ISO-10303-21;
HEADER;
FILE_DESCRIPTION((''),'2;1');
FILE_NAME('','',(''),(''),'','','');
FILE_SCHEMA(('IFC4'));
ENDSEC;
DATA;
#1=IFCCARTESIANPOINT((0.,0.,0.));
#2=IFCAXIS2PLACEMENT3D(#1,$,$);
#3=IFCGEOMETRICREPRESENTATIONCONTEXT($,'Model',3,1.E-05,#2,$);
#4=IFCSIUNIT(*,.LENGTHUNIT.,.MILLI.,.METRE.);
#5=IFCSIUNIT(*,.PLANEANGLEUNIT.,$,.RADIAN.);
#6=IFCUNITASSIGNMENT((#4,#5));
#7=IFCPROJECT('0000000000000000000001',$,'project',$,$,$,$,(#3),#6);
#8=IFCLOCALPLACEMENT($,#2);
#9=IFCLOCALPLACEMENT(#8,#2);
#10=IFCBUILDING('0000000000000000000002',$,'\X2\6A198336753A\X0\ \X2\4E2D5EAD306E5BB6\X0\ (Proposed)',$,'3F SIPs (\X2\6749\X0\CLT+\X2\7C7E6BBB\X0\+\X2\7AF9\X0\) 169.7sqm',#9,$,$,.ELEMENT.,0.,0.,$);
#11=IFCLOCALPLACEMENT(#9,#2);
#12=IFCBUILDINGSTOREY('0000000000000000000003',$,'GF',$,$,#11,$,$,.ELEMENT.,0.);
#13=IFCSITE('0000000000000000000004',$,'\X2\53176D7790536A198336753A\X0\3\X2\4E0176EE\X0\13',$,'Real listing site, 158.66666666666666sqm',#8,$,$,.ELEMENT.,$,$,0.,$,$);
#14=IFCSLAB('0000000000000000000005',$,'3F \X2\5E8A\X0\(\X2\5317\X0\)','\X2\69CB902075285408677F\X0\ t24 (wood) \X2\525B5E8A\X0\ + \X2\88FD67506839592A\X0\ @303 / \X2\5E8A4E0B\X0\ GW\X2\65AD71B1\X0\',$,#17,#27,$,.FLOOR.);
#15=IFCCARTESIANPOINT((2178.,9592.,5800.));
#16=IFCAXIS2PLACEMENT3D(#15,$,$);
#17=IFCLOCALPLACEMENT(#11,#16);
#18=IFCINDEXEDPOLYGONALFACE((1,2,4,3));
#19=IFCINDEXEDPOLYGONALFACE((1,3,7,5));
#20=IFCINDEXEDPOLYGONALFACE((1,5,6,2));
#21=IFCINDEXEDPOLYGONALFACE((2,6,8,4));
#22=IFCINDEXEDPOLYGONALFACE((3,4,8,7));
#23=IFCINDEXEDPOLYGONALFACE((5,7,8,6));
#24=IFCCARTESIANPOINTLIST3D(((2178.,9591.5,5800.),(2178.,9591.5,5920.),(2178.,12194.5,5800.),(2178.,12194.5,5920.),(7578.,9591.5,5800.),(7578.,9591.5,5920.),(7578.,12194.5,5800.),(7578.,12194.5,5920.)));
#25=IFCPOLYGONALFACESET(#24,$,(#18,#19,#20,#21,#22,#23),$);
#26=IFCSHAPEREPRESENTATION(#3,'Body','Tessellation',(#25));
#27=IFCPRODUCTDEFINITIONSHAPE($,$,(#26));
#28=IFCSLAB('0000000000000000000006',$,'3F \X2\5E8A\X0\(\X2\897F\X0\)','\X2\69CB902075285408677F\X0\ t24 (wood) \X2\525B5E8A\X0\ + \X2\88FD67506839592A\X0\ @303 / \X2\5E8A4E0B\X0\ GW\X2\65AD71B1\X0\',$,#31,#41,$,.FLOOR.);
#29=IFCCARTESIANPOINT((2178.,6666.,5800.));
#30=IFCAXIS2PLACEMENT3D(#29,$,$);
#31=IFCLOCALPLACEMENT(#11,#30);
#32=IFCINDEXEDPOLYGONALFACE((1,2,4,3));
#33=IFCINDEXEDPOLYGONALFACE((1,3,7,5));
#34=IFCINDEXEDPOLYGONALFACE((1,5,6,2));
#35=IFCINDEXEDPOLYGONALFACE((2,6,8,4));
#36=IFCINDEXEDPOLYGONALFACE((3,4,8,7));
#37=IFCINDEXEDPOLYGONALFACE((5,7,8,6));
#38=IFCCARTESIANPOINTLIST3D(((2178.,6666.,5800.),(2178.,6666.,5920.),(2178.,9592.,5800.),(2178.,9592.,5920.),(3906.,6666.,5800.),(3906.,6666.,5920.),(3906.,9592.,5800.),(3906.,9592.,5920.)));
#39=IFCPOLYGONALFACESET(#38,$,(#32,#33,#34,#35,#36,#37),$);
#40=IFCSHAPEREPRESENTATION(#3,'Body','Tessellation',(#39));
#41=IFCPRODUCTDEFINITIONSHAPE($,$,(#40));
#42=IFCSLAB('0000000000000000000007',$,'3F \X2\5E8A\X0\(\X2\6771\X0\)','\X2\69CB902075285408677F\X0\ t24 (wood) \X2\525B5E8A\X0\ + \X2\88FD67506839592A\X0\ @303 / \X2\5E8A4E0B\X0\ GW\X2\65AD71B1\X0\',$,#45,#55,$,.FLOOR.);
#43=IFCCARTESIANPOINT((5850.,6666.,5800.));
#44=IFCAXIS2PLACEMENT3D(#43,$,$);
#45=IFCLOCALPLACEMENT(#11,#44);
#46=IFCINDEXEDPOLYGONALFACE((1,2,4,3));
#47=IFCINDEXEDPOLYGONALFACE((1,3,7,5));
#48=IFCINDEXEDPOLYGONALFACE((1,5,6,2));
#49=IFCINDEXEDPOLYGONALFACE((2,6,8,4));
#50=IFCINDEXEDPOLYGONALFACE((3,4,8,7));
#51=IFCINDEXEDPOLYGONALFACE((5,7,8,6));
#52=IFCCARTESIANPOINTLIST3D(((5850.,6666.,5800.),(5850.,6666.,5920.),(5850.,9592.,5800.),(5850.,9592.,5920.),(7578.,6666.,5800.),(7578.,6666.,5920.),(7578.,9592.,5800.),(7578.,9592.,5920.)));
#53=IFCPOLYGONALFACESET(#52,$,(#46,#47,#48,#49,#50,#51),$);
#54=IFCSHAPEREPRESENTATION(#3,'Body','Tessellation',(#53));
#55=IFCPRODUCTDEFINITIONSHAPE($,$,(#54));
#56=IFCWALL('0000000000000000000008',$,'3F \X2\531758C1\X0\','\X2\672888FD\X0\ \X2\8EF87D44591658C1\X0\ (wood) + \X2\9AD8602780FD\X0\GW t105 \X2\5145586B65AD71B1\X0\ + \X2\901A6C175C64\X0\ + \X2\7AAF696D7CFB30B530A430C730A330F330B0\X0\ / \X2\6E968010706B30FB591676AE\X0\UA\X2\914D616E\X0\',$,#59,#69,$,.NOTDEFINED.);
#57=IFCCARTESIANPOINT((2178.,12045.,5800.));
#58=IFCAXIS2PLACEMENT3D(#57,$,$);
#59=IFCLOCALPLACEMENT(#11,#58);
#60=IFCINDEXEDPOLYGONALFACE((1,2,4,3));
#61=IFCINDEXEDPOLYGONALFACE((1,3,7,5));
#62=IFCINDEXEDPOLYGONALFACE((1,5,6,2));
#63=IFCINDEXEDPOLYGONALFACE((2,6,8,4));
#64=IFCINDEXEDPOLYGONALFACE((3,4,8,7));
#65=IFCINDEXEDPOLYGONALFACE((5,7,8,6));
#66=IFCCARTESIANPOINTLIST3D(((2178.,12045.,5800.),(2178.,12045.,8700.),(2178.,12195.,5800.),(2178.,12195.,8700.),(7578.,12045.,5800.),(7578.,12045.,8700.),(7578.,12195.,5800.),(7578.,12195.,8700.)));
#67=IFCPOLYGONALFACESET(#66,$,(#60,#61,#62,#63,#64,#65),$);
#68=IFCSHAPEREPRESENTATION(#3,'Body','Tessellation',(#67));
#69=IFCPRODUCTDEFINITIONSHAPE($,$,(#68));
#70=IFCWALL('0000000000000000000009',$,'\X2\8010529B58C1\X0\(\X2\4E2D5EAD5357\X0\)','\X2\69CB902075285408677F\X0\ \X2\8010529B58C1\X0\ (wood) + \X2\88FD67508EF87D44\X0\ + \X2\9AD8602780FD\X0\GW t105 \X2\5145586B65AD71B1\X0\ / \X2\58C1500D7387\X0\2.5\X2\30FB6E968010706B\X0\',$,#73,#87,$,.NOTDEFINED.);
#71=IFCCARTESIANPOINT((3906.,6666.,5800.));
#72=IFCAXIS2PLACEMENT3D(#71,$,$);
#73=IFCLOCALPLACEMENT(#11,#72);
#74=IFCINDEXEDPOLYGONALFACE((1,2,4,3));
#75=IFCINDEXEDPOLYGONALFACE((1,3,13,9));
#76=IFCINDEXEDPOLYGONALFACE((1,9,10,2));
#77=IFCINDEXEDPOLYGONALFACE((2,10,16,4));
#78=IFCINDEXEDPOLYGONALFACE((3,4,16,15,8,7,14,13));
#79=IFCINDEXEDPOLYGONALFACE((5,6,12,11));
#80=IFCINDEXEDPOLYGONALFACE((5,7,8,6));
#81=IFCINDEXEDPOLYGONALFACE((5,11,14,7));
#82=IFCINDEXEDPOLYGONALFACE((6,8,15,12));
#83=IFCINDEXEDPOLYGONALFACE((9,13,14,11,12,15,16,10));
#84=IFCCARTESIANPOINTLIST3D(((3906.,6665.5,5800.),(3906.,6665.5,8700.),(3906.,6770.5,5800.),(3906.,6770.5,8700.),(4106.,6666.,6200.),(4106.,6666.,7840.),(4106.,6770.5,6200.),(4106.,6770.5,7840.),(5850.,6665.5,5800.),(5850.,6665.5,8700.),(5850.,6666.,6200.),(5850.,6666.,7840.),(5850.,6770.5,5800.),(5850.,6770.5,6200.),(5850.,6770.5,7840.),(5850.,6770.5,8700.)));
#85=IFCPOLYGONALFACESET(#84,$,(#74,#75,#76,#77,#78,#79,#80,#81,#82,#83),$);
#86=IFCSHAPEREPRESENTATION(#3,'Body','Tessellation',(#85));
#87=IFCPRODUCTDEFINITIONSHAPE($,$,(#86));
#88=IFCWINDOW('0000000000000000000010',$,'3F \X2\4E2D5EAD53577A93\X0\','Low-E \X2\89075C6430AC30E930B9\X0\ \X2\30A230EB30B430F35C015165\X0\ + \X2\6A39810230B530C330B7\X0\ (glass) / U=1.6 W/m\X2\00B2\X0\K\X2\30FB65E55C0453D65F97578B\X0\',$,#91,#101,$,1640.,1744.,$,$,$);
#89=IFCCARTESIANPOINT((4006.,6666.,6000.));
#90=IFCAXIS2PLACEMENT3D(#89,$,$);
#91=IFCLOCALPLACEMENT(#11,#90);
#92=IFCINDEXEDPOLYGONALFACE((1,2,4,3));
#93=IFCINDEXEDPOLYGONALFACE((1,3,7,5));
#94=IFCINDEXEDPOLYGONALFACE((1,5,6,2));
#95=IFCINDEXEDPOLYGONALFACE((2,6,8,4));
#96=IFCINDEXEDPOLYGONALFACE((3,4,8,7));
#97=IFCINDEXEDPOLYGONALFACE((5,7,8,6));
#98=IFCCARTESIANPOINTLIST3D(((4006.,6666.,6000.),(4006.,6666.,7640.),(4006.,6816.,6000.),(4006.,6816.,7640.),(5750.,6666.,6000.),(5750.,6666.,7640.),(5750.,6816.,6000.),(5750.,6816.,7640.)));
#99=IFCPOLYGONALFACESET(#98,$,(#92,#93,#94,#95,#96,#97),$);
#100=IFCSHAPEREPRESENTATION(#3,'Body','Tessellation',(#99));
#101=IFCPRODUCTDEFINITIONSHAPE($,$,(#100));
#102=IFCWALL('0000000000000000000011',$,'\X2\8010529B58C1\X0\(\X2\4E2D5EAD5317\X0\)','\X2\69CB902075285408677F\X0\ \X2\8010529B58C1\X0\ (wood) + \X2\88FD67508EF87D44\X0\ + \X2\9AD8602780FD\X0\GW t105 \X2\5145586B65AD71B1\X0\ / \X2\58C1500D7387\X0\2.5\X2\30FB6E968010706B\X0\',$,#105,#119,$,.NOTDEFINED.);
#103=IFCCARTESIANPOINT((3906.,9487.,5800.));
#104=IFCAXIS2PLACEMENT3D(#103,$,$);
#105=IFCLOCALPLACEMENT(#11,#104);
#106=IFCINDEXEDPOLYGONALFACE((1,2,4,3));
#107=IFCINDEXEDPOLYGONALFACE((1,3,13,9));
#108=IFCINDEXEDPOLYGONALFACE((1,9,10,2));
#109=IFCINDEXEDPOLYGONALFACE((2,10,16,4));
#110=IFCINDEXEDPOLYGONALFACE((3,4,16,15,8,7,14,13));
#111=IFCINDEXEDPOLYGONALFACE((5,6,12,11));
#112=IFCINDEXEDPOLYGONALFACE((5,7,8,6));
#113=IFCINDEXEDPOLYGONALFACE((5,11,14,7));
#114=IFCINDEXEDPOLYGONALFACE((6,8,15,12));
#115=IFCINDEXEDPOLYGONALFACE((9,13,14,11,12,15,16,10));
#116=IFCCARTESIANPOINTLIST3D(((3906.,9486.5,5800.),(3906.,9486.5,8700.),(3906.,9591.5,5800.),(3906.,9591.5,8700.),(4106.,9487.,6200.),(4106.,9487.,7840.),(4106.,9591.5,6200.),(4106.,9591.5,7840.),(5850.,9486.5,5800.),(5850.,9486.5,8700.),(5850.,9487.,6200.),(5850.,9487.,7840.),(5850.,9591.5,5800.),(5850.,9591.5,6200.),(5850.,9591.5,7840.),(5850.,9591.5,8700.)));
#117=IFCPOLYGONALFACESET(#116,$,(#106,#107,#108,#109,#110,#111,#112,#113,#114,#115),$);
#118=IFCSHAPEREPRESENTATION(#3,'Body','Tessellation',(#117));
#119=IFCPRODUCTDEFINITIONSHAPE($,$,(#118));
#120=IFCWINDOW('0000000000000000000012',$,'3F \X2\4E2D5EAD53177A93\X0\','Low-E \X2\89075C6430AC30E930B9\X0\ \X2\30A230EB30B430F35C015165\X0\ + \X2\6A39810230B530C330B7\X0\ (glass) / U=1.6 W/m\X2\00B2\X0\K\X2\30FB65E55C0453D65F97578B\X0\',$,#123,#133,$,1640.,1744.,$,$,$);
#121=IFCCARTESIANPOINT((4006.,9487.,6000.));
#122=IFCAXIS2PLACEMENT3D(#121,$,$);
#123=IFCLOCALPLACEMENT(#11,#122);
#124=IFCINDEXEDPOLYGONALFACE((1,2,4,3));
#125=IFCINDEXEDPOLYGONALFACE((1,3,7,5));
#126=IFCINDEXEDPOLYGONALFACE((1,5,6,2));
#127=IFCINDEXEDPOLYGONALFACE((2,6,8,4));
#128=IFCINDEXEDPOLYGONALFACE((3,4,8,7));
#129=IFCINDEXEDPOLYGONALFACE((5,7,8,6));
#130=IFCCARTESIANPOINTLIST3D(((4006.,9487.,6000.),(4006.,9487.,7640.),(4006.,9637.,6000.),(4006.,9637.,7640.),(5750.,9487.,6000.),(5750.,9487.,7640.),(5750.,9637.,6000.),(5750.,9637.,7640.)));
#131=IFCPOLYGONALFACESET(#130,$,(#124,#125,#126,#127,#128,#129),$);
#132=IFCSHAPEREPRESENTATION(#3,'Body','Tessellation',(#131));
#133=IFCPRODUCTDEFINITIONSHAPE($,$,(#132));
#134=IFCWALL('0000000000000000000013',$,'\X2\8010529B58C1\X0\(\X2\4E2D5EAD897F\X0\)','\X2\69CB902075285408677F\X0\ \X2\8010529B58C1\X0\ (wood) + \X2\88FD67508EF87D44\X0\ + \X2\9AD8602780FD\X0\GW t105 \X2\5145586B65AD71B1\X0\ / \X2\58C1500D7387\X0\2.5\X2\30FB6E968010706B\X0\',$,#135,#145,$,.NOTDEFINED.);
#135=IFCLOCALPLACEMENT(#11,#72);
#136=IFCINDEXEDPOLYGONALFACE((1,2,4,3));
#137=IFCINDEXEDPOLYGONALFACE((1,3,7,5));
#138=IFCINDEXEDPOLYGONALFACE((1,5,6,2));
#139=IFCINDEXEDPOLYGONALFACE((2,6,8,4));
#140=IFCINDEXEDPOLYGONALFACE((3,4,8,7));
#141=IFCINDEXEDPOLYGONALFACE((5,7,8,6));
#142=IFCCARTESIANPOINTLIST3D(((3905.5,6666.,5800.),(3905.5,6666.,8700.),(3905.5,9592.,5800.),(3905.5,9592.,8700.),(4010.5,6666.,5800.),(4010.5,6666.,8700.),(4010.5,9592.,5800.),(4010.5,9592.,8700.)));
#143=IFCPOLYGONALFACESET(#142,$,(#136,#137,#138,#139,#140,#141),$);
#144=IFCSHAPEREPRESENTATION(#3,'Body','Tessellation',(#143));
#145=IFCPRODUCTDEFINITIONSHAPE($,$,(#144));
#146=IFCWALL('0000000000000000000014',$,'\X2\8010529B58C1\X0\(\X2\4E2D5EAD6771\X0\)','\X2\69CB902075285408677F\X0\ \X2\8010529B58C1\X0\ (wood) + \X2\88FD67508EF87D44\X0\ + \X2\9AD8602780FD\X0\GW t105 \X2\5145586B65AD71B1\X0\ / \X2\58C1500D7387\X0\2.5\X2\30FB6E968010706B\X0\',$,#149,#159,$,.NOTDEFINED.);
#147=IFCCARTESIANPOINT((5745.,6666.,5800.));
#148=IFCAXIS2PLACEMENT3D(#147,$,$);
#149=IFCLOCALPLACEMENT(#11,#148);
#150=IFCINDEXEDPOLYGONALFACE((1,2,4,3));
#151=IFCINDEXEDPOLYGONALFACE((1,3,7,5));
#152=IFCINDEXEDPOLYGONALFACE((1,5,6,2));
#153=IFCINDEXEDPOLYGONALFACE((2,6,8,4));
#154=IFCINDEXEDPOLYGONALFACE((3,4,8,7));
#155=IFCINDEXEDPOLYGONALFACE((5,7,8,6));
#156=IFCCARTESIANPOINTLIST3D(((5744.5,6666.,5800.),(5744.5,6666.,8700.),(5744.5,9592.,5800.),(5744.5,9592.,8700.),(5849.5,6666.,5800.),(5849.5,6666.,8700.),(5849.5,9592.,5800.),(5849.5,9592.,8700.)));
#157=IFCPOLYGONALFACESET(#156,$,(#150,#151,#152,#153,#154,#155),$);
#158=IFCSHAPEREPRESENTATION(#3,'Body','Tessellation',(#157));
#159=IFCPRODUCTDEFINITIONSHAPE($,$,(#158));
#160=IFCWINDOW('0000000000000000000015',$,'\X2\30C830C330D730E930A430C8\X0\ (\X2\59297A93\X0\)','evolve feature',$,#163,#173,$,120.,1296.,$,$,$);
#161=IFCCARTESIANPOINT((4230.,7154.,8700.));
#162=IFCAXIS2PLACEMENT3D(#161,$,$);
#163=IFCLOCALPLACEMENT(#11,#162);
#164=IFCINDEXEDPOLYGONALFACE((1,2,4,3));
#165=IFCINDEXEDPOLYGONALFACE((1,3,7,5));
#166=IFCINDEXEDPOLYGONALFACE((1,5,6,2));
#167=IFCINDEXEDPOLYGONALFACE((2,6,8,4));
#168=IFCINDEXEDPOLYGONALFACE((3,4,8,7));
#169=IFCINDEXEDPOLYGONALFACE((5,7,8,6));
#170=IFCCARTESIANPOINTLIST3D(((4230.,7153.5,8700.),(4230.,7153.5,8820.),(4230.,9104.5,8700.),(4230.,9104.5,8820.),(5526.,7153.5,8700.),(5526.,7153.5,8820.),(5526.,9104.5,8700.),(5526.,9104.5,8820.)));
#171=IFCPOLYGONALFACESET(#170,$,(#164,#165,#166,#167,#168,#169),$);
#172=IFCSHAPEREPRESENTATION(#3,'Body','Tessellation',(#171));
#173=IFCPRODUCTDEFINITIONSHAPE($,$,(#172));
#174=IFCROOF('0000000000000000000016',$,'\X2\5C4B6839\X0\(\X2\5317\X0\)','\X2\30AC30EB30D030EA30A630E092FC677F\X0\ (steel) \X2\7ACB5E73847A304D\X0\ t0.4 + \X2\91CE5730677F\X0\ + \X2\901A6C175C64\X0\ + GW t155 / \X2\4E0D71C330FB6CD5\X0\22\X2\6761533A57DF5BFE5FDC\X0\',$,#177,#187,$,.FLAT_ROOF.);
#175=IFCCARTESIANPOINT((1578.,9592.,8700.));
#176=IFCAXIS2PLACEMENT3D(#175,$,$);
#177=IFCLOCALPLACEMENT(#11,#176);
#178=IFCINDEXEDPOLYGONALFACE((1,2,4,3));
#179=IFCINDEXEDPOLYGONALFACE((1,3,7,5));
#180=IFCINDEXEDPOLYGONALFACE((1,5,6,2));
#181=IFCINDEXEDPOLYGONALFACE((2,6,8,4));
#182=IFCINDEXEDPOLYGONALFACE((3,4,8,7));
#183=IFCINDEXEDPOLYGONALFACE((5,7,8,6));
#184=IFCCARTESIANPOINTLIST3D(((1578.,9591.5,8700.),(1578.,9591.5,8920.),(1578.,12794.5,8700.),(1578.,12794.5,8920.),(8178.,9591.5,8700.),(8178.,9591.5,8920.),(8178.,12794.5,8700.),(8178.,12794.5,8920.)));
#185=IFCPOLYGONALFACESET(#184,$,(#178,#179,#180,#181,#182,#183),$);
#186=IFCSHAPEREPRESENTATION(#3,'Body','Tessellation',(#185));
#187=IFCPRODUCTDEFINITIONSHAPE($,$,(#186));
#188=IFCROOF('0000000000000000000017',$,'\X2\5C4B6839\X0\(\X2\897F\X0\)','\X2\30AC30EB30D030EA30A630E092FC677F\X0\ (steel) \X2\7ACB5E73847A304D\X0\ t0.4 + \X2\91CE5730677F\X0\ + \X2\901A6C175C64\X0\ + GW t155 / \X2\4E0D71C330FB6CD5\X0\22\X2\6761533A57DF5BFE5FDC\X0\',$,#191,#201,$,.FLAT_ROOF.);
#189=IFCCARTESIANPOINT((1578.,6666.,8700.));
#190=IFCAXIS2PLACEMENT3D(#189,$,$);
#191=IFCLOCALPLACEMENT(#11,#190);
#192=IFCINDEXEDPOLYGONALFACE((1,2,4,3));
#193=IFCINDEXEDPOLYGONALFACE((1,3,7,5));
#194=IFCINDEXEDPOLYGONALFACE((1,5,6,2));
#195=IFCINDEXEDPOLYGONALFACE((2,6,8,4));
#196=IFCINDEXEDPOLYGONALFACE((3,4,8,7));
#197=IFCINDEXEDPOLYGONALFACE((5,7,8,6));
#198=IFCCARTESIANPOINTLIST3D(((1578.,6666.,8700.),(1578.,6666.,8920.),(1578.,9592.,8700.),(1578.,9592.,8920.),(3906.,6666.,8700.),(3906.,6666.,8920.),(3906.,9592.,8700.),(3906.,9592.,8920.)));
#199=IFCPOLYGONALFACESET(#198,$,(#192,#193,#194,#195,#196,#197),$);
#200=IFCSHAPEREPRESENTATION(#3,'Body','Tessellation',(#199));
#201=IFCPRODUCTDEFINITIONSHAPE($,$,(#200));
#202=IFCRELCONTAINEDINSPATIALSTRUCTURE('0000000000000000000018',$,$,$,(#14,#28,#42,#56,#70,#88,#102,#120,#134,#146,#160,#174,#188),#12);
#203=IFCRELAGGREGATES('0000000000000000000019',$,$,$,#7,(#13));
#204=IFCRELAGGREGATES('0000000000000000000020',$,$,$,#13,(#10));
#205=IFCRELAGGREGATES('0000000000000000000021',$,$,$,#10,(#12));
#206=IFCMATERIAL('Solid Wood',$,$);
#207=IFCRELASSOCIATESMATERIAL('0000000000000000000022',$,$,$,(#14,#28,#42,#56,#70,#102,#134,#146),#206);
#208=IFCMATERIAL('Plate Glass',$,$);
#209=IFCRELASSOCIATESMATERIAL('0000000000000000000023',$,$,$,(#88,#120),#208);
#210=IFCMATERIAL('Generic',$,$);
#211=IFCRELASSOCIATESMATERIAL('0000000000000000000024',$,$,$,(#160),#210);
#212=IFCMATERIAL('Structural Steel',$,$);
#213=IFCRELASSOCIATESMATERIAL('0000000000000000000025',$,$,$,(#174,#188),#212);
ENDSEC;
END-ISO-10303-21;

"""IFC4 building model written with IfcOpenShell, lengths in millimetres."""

from ifc_helpers import new_model, si_unit, frame, frame_2d, origin, place, context, project, spatial, rectangle, extrude, material, element, fill, save


model = new_model("IFC4")

# Units and contexts
model_context = context("Model", 3, precision=1e-05, world=origin())
ifc_project = project(units=[si_unit("LENGTHUNIT", "METRE", prefix="MILLI"), si_unit("PLANEANGLEUNIT", "RADIAN")], contexts=[model_context])

# Site, building, storey
site_placement = place(None, origin())
site = spatial("IfcSite", under=ifc_project, at=site_placement, Name="北海道標茶町3丁目13", ObjectType="Real listing site, 158.66666666666666sqm", CompositionType="ELEMENT", RefElevation=0.0)
building_placement = place(site_placement, origin())
building = spatial("IfcBuilding", under=site, at=building_placement, Name="標茶町 中庭の家 (Proposed)", ObjectType="3F SIPs (杉CLT+籾殻+竹) 169.7sqm", CompositionType="ELEMENT", ElevationOfRefHeight=0.0, ElevationOfTerrain=0.0)
storey_placement = place(building_placement, origin())
storey = spatial("IfcBuildingStorey", under=building, at=storey_placement, Name="GF", CompositionType="ELEMENT", Elevation=0.0)

# Slabs
ifc_material_1 = material(Name="Solid Wood")
slab_1_placement = place(storey_placement, frame((2178.0, 9592.0, 5800.0)))
element("IfcSlab", 1, at=slab_1_placement, inside=storey, material=ifc_material_1, Name="3F 床(北)", Description="構造用合板 t24 (wood) 剛床 + 製材根太 @303 / 床下 GW断熱", PredefinedType="FLOOR", context=model_context, shape_type="SweptSolid", body=[
    extrude(rectangle(XDim=5400.0, YDim=2603.0, at=frame_2d((2700.0, 1301.0))), frame((2178.0, 9592.0, 5800.0)), (0.0, 0.0, 1.0), 120.0),
])
slab_2_placement = place(storey_placement, frame((2178.0, 6666.0, 5800.0)))
element("IfcSlab", 2, at=slab_2_placement, inside=storey, material=ifc_material_1, Name="3F 床(西)", Description="構造用合板 t24 (wood) 剛床 + 製材根太 @303 / 床下 GW断熱", PredefinedType="FLOOR", context=model_context, shape_type="SweptSolid", body=[
    extrude(rectangle(XDim=1728.0, YDim=2926.0, at=frame_2d((864.0, 1463.0))), frame((2178.0, 6666.0, 5800.0)), (0.0, 0.0, 1.0), 120.0),
])
slab_3_placement = place(storey_placement, frame((5850.0, 6666.0, 5800.0)))
element("IfcSlab", 3, at=slab_3_placement, inside=storey, material=ifc_material_1, Name="3F 床(東)", Description="構造用合板 t24 (wood) 剛床 + 製材根太 @303 / 床下 GW断熱", PredefinedType="FLOOR", context=model_context, shape_type="SweptSolid", body=[
    extrude(rectangle(XDim=1728.0, YDim=2926.0, at=frame_2d((864.0, 1463.0))), frame((5850.0, 6666.0, 5800.0)), (0.0, 0.0, 1.0), 120.0),
])

# Wall
wall_1_placement = place(storey_placement, frame((2178.0, 12045.0, 5800.0)))
element("IfcWall", 4, at=wall_1_placement, inside=storey, material=ifc_material_1, Name="3F 北壁", Description="木製 軸組外壁 (wood) + 高性能GW t105 充填断熱 + 通気層 + 窯業系サイディング / 準耐火・外皮UA配慮", PredefinedType="NOTDEFINED", context=model_context, shape_type="SweptSolid", body=[
    extrude(rectangle(XDim=5400.0, YDim=150.0, at=frame_2d((2700.0, 75.0))), frame((2178.0, 12045.0, 5800.0)), (0.0, 0.0, 1.0), 2900.0),
])

# Walls, openings, windows
wall_2_placement = place(storey_placement, frame((3906.0, 6666.0, 5800.0)))
wall_2 = element("IfcWall", 5, at=wall_2_placement, inside=storey, material=ifc_material_1, Name="耐力壁(中庭南)", Description="構造用合板 耐力壁 (wood) + 製材軸組 + 高性能GW t105 充填断熱 / 壁倍率2.5・準耐火", PredefinedType="NOTDEFINED", context=model_context, shape_type="SweptSolid", body=[
    extrude(rectangle(XDim=1944.0, YDim=105.0, at=frame_2d((972.0, 52.0))), frame((3906.0, 6666.0, 5800.0)), (0.0, 0.0, 1.0), 2900.0),
])
opening_1_placement = place(storey_placement, frame((4006.0, 6666.0, 6000.0)))
opening_1 = element("IfcOpeningElement", 6, at=opening_1_placement, cuts=wall_2, PredefinedType="NOTDEFINED", context=model_context, shape_type="SweptSolid", body=[
    extrude(rectangle(XDim=1744.0, YDim=150.0, at=frame_2d((872.0, 75.0))), frame((4006.0, 6666.0, 6000.0)), (0.0, 0.0, 1.0), 1640.0),
])
ifc_material_2 = material(Name="Plate Glass")
window_1_placement = place(storey_placement, frame((4006.0, 6666.0, 6000.0)))
window_1 = element("IfcWindow", 7, at=window_1_placement, inside=storey, material=ifc_material_2, Name="3F 中庭南窓", Description="Low-E 複層ガラス アルゴン封入 + 樹脂サッシ (glass) / U=1.6 W/m²K・日射取得型", OverallHeight=1640.0, OverallWidth=1744.0, context=model_context, shape_type="SweptSolid", body=[
    extrude(rectangle(XDim=1744.0, YDim=150.0, at=frame_2d((872.0, 75.0))), frame((4006.0, 6666.0, 6000.0)), (0.0, 0.0, 1.0), 1640.0),
])
fill(opening_1, window_1)
wall_3_placement = place(storey_placement, frame((3906.0, 9487.0, 5800.0)))
wall_3 = element("IfcWall", 8, at=wall_3_placement, inside=storey, material=ifc_material_1, Name="耐力壁(中庭北)", Description="構造用合板 耐力壁 (wood) + 製材軸組 + 高性能GW t105 充填断熱 / 壁倍率2.5・準耐火", PredefinedType="NOTDEFINED", context=model_context, shape_type="SweptSolid", body=[
    extrude(rectangle(XDim=1944.0, YDim=105.0, at=frame_2d((972.0, 52.0))), frame((3906.0, 9487.0, 5800.0)), (0.0, 0.0, 1.0), 2900.0),
])
opening_2_placement = place(storey_placement, frame((4006.0, 9487.0, 6000.0)))
opening_2 = element("IfcOpeningElement", 9, at=opening_2_placement, cuts=wall_3, PredefinedType="NOTDEFINED", context=model_context, shape_type="SweptSolid", body=[
    extrude(rectangle(XDim=1744.0, YDim=150.0, at=frame_2d((872.0, 75.0))), frame((4006.0, 9487.0, 6000.0)), (0.0, 0.0, 1.0), 1640.0),
])
window_2_placement = place(storey_placement, frame((4006.0, 9487.0, 6000.0)))
window_2 = element("IfcWindow", 10, at=window_2_placement, inside=storey, material=ifc_material_2, Name="3F 中庭北窓", Description="Low-E 複層ガラス アルゴン封入 + 樹脂サッシ (glass) / U=1.6 W/m²K・日射取得型", OverallHeight=1640.0, OverallWidth=1744.0, context=model_context, shape_type="SweptSolid", body=[
    extrude(rectangle(XDim=1744.0, YDim=150.0, at=frame_2d((872.0, 75.0))), frame((4006.0, 9487.0, 6000.0)), (0.0, 0.0, 1.0), 1640.0),
])
fill(opening_2, window_2)

# Walls
wall_4_placement = place(storey_placement, frame((3906.0, 6666.0, 5800.0)))
element("IfcWall", 11, at=wall_4_placement, inside=storey, material=ifc_material_1, Name="耐力壁(中庭西)", Description="構造用合板 耐力壁 (wood) + 製材軸組 + 高性能GW t105 充填断熱 / 壁倍率2.5・準耐火", PredefinedType="NOTDEFINED", context=model_context, shape_type="SweptSolid", body=[
    extrude(rectangle(XDim=105.0, YDim=2926.0, at=frame_2d((52.0, 1463.0))), frame((3906.0, 6666.0, 5800.0)), (0.0, 0.0, 1.0), 2900.0),
])
wall_5_placement = place(storey_placement, frame((5745.0, 6666.0, 5800.0)))
element("IfcWall", 12, at=wall_5_placement, inside=storey, material=ifc_material_1, Name="耐力壁(中庭東)", Description="構造用合板 耐力壁 (wood) + 製材軸組 + 高性能GW t105 充填断熱 / 壁倍率2.5・準耐火", PredefinedType="NOTDEFINED", context=model_context, shape_type="SweptSolid", body=[
    extrude(rectangle(XDim=105.0, YDim=2926.0, at=frame_2d((52.0, 1463.0))), frame((5745.0, 6666.0, 5800.0)), (0.0, 0.0, 1.0), 2900.0),
])

# Window
ifc_material_3 = material(Name="Generic")
window_3_placement = place(storey_placement, frame((4230.0, 7154.0, 8700.0)))
element("IfcWindow", 13, at=window_3_placement, inside=storey, material=ifc_material_3, Name="トップライト (天窓)", Description="evolve feature", OverallHeight=120.0, OverallWidth=1296.0, context=model_context, shape_type="SweptSolid", body=[
    extrude(rectangle(XDim=1296.0, YDim=1951.0, at=frame_2d((648.0, 975.0))), frame((4230.0, 7154.0, 8700.0)), (0.0, 0.0, 1.0), 120.0),
])

# Roofs
ifc_material_4 = material(Name="Structural Steel")
for number, where, name in (
    (14, (1578.0, 9592.0, 8700.0), "屋根(北)"),
):
    element("IfcRoof", number, at=place(storey_placement, frame(where)), inside=storey, material=ifc_material_4, Name=name, Description="ガルバリウム鋼板 (steel) 立平葺き t0.4 + 野地板 + 通気層 + GW t155 / 不燃・法22条区域対応", PredefinedType="FLAT_ROOF", context=model_context, shape_type="SweptSolid", body=[
        extrude(rectangle(XDim=6600.0, YDim=3203.0, at=frame_2d((3300.0, 1601.0))), frame((1578.0, 9592.0, 8700.0)), (0.0, 0.0, 1.0), 220.0),
    ])
roof_1_placement = place(storey_placement, frame((1578.0, 6666.0, 8700.0)))
element("IfcRoof", 15, at=roof_1_placement, inside=storey, material=ifc_material_4, Name="屋根(西)", Description="ガルバリウム鋼板 (steel) 立平葺き t0.4 + 野地板 + 通気層 + GW t155 / 不燃・法22条区域対応", PredefinedType="FLAT_ROOF", context=model_context, shape_type="SweptSolid", body=[
    extrude(rectangle(XDim=2328.0, YDim=2926.0, at=frame_2d((1164.0, 1463.0))), frame((1578.0, 6666.0, 8700.0)), (0.0, 0.0, 1.0), 220.0),
])

save(model, "model.ifc")
